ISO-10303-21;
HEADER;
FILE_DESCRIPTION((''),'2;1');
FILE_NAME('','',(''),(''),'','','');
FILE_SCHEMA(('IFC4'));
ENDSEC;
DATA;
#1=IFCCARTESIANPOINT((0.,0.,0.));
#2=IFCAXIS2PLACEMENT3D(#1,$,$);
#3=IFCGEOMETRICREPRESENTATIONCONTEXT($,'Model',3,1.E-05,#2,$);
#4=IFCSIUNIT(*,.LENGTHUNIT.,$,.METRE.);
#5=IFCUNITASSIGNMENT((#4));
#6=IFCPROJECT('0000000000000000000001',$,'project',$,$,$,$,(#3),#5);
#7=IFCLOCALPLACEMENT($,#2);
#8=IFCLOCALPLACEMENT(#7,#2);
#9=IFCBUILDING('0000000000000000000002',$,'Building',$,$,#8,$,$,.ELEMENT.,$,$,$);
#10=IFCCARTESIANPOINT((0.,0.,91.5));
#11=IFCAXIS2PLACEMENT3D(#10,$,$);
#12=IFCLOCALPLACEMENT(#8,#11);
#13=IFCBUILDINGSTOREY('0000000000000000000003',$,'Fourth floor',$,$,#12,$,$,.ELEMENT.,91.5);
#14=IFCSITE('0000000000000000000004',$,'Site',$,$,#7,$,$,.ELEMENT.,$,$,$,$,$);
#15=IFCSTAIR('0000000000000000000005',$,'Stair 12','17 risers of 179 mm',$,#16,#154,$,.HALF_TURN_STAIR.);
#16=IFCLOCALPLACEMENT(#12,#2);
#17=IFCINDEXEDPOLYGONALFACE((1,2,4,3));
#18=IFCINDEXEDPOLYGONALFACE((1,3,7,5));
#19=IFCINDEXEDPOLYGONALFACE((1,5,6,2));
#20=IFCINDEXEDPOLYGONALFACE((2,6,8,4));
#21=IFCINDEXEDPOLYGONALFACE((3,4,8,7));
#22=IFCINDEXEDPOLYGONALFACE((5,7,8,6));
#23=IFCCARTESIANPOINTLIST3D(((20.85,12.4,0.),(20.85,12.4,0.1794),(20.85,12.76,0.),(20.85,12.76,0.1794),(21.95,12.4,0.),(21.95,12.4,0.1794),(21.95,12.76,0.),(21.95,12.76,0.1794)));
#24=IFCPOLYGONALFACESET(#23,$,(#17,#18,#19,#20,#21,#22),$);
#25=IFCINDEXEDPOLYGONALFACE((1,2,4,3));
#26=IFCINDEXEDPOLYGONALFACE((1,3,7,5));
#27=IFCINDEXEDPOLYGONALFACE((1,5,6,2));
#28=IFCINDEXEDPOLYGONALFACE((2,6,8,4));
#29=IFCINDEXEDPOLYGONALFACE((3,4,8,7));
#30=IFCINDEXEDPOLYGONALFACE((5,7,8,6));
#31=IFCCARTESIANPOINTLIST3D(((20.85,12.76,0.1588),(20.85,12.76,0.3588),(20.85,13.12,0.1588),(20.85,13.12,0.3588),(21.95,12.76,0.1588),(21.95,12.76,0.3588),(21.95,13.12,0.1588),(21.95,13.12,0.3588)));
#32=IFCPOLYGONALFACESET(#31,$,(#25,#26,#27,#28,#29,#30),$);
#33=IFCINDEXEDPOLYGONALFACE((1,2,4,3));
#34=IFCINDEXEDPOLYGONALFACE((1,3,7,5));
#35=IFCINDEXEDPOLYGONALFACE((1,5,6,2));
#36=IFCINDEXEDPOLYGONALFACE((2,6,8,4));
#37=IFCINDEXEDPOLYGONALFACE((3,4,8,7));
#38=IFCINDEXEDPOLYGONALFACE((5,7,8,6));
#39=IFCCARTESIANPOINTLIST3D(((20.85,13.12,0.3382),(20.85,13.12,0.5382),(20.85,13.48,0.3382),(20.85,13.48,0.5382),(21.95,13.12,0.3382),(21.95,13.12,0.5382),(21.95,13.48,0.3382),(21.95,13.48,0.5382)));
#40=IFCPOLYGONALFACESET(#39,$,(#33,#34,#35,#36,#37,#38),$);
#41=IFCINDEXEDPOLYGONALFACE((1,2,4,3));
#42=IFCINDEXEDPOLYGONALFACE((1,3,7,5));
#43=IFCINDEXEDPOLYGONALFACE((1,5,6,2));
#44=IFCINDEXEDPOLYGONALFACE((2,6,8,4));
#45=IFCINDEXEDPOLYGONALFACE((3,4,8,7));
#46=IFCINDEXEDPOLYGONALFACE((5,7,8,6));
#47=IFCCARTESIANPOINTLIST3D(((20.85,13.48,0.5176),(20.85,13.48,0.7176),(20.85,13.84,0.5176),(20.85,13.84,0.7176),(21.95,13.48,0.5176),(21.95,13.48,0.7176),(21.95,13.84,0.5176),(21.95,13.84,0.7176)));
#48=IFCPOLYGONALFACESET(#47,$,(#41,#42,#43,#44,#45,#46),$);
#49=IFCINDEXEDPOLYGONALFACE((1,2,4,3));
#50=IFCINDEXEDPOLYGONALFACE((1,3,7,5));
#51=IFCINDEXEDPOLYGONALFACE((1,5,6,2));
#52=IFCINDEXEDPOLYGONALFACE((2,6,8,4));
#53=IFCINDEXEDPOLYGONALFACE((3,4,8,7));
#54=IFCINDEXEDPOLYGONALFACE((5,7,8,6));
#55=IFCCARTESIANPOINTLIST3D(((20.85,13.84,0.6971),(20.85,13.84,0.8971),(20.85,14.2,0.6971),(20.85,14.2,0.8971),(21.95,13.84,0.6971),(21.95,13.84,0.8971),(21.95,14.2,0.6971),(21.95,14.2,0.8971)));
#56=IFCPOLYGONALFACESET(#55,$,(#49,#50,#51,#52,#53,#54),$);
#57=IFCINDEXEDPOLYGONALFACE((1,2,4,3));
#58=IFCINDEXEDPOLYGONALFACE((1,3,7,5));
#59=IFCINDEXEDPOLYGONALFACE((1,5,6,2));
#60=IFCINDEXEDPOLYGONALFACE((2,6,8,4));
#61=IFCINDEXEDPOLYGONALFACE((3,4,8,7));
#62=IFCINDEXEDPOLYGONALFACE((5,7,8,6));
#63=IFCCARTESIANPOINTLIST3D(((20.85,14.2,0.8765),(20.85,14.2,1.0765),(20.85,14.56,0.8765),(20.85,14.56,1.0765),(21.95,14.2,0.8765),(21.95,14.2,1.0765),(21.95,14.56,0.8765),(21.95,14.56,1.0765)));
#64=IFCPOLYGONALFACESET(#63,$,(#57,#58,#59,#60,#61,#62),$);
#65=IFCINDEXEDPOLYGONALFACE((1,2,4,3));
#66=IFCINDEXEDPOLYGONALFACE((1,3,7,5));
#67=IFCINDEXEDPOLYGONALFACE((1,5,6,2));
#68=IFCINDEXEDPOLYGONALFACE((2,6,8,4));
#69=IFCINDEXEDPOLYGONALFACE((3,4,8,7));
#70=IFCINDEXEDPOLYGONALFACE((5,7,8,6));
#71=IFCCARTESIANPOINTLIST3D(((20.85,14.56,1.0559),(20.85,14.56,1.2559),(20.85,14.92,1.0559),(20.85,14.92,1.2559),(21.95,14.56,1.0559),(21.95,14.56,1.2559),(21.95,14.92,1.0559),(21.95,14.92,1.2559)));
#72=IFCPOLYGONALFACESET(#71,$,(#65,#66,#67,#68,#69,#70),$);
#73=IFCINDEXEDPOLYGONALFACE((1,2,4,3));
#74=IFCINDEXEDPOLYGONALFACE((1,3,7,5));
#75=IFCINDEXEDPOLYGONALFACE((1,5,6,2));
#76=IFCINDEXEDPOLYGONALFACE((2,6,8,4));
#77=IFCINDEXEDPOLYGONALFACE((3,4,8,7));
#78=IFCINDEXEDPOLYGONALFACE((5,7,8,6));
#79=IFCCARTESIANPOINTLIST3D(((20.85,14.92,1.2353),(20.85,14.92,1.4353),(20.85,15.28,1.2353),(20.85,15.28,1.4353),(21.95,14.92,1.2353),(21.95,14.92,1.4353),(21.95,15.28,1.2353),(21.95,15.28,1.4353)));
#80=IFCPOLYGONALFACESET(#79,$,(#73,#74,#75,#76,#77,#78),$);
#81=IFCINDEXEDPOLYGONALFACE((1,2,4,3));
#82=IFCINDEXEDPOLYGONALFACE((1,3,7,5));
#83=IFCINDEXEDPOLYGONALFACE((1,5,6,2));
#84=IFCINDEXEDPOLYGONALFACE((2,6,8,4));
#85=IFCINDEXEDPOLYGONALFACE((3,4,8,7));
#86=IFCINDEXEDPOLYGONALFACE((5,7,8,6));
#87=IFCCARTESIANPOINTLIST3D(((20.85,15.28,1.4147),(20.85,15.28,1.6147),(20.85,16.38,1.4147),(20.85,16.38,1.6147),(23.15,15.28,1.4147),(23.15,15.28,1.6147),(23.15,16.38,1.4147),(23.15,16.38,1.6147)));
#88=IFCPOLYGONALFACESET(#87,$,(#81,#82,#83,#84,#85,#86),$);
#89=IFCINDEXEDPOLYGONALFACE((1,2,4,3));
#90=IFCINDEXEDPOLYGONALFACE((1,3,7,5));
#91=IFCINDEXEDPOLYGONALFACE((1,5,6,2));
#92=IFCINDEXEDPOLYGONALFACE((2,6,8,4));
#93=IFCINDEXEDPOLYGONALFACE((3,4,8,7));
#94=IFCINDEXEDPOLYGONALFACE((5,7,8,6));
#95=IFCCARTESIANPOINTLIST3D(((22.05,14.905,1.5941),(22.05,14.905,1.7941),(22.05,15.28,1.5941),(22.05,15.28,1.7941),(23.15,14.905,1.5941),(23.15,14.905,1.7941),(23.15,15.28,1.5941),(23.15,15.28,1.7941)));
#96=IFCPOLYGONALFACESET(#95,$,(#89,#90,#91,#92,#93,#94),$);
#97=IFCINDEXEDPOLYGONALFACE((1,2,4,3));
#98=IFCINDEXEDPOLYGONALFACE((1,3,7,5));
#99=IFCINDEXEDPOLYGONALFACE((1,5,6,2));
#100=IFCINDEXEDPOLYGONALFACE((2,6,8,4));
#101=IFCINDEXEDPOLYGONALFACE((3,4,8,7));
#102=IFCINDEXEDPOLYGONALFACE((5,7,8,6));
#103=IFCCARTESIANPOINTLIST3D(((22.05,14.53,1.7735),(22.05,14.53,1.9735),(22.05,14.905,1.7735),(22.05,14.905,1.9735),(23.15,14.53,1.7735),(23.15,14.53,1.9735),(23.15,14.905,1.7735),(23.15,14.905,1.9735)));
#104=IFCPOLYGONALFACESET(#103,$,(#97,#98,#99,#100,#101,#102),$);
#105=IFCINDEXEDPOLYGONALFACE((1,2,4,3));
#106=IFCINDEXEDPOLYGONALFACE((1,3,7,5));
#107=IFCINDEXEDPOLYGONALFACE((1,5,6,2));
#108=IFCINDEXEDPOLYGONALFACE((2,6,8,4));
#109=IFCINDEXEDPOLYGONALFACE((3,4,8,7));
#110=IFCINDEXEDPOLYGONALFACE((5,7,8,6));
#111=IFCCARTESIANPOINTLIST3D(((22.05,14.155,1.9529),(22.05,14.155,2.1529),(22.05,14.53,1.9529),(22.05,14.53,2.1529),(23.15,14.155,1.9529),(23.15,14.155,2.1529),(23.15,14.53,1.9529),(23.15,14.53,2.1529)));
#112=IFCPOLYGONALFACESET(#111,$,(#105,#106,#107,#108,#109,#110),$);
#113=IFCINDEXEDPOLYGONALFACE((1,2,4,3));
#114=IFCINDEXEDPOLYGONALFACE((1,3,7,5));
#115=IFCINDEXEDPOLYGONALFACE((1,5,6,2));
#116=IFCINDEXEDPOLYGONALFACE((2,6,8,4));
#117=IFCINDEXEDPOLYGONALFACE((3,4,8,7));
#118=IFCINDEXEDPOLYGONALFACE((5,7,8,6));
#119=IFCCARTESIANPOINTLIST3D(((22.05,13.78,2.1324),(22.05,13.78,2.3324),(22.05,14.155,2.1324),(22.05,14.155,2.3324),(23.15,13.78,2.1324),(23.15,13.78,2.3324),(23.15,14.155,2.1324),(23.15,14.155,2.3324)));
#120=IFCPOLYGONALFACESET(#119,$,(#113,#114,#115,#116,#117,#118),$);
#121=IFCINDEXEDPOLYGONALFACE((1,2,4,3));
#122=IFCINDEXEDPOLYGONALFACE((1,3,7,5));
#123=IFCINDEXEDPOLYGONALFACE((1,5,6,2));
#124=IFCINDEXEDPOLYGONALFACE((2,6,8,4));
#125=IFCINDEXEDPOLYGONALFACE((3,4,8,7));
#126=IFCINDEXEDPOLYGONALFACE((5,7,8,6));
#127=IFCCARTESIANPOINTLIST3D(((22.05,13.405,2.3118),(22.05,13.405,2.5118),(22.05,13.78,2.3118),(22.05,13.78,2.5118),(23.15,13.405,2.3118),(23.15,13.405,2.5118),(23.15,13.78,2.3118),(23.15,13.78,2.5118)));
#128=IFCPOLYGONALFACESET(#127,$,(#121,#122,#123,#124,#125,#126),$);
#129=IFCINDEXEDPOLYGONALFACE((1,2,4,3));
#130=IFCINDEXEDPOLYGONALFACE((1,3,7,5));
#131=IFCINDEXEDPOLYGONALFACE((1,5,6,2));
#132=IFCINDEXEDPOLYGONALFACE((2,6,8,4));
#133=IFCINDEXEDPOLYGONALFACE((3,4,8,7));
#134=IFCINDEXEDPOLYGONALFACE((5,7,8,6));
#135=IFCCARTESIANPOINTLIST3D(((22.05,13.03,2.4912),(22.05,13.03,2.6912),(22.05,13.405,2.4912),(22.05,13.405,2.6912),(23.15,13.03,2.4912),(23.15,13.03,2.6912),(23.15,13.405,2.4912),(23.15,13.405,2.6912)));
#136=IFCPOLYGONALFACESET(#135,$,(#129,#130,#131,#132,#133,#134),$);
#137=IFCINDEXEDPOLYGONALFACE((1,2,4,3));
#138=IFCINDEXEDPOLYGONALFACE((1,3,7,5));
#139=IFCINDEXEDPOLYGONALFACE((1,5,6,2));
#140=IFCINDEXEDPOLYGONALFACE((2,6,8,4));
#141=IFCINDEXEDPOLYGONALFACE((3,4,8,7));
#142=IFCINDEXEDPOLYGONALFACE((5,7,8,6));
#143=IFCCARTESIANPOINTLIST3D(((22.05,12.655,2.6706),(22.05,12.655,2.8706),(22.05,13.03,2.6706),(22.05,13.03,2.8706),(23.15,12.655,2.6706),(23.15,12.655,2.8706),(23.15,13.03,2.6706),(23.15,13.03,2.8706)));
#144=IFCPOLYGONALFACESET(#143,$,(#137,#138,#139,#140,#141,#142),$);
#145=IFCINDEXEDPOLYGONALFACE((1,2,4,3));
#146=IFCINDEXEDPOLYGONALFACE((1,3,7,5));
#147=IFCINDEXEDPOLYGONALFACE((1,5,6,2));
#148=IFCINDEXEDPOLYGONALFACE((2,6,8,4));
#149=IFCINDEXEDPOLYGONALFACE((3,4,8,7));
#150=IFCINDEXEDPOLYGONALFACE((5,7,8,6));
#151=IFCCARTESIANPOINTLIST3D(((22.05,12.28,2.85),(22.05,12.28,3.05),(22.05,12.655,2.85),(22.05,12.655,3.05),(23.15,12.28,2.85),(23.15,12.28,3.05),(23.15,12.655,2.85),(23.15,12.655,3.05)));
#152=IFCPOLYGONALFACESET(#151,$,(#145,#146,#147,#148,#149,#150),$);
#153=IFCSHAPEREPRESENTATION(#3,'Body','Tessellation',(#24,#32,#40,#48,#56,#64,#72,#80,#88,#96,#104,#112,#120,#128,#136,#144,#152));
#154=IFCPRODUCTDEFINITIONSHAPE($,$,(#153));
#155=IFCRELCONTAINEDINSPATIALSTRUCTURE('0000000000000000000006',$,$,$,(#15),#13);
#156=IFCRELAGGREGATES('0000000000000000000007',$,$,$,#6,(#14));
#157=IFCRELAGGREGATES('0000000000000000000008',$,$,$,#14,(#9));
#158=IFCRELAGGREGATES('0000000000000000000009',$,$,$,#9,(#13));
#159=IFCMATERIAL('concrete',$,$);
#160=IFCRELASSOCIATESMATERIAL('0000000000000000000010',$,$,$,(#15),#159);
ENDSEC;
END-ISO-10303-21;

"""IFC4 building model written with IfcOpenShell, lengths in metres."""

from ifc_helpers import new_model, si_unit, frame, origin, place, context, project, spatial, polyline, outline, extrude, material, element, save


model = new_model("IFC4")

# Units and contexts
model_context = context("Model", 3, precision=1e-05, world=origin())
ifc_project = project(units=[si_unit("LENGTHUNIT", "METRE")], contexts=[model_context])

# Site, building, storey
site_placement = place(None, origin())
site = spatial("IfcSite", under=ifc_project, at=site_placement, Name="Site", CompositionType="ELEMENT")
building_placement = place(site_placement, origin())
building = spatial("IfcBuilding", under=site, at=building_placement, Name="Building", CompositionType="ELEMENT")
storey_placement = place(building_placement, frame((0.0, 0.0, 91.5)))
storey = spatial("IfcBuildingStorey", under=building, at=storey_placement, Name="Fourth floor", CompositionType="ELEMENT", Elevation=91.5)

# Shared definitions
ifc_material = material(Name="concrete")

# Stair
stair_1_placement = place(storey_placement, frame((21.4, 12.4, 0.0), z_axis=(0.0, 0.0, 1.0), x_axis=(0.0, 1.0, 0.0)))
element("IfcStair", 1, at=stair_1_placement, inside=storey, material=ifc_material, Name="Stair 12", Description="17 risers of 179 mm", PredefinedType="HALF_TURN_STAIR", context=model_context, shape_type="SweptSolid", body=[
    extrude(outline(polyline([(0.0, -0.55), (0.36, -0.55), (0.36, 0.55), (0.0, 0.55), (0.0, -0.55)])), origin(), (0.0, 0.0, 1.0), 0.1794),
    extrude(outline(polyline([(0.36, -0.55), (0.72, -0.55), (0.72, 0.55), (0.36, 0.55), (0.36, -0.55)])), frame((0.0, 0.0, 0.1588)), (0.0, 0.0, 1.0), 0.2),
    extrude(outline(polyline([(0.72, -0.55), (1.08, -0.55), (1.08, 0.55), (0.72, 0.55), (0.72, -0.55)])), frame((0.0, 0.0, 0.3382)), (0.0, 0.0, 1.0), 0.2),
    extrude(outline(polyline([(1.08, -0.55), (1.44, -0.55), (1.44, 0.55), (1.08, 0.55), (1.08, -0.55)])), frame((0.0, 0.0, 0.5176)), (0.0, 0.0, 1.0), 0.2),
    extrude(outline(polyline([(1.44, -0.55), (1.8, -0.55), (1.8, 0.55), (1.44, 0.55), (1.44, -0.55)])), frame((0.0, 0.0, 0.6971)), (0.0, 0.0, 1.0), 0.2),
    extrude(outline(polyline([(1.8, -0.55), (2.16, -0.55), (2.16, 0.55), (1.8, 0.55), (1.8, -0.55)])), frame((0.0, 0.0, 0.8765)), (0.0, 0.0, 1.0), 0.2),
    extrude(outline(polyline([(2.16, -0.55), (2.52, -0.55), (2.52, 0.55), (2.16, 0.55), (2.16, -0.55)])), frame((0.0, 0.0, 1.0559)), (0.0, 0.0, 1.0), 0.2),
    extrude(outline(polyline([(2.52, -0.55), (2.88, -0.55), (2.88, 0.55), (2.52, 0.55), (2.52, -0.55)])), frame((0.0, 0.0, 1.2353)), (0.0, 0.0, 1.0), 0.2),
    extrude(outline(polyline([(2.88, -1.75), (3.98, -1.75), (3.98, 0.55), (2.88, 0.55), (2.88, -1.75)])), frame((0.0, 0.0, 1.4147)), (0.0, 0.0, 1.0), 0.2),
    extrude(outline(polyline([(2.505, -1.75), (2.88, -1.75), (2.88, -0.65), (2.505, -0.65), (2.505, -1.75)])), frame((0.0, 0.0, 1.5941)), (0.0, 0.0, 1.0), 0.2),
    extrude(outline(polyline([(2.13, -1.75), (2.505, -1.75), (2.505, -0.65), (2.13, -0.65), (2.13, -1.75)])), frame((0.0, 0.0, 1.7735)), (0.0, 0.0, 1.0), 0.2),
    extrude(outline(polyline([(1.755, -1.75), (2.13, -1.75), (2.13, -0.65), (1.755, -0.65), (1.755, -1.75)])), frame((0.0, 0.0, 1.9529)), (0.0, 0.0, 1.0), 0.2),
    extrude(outline(polyline([(1.38, -1.75), (1.755, -1.75), (1.755, -0.65), (1.38, -0.65), (1.38, -1.75)])), frame((0.0, 0.0, 2.1324)), (0.0, 0.0, 1.0), 0.2),
    extrude(outline(polyline([(1.005, -1.75), (1.38, -1.75), (1.38, -0.65), (1.005, -0.65), (1.005, -1.75)])), frame((0.0, 0.0, 2.3118)), (0.0, 0.0, 1.0), 0.2),
    extrude(outline(polyline([(0.63, -1.75), (1.005, -1.75), (1.005, -0.65), (0.63, -0.65), (0.63, -1.75)])), frame((0.0, 0.0, 2.4912)), (0.0, 0.0, 1.0), 0.2),
    extrude(outline(polyline([(0.255, -1.75), (0.63, -1.75), (0.63, -0.65), (0.255, -0.65), (0.255, -1.75)])), frame((0.0, 0.0, 2.6706)), (0.0, 0.0, 1.0), 0.2),
    extrude(outline(polyline([(-0.12, -1.75), (0.255, -1.75), (0.255, -0.65), (-0.12, -0.65), (-0.12, -1.75)])), frame((0.0, 0.0, 2.85)), (0.0, 0.0, 1.0), 0.2),
])

save(model, "model.ifc")
